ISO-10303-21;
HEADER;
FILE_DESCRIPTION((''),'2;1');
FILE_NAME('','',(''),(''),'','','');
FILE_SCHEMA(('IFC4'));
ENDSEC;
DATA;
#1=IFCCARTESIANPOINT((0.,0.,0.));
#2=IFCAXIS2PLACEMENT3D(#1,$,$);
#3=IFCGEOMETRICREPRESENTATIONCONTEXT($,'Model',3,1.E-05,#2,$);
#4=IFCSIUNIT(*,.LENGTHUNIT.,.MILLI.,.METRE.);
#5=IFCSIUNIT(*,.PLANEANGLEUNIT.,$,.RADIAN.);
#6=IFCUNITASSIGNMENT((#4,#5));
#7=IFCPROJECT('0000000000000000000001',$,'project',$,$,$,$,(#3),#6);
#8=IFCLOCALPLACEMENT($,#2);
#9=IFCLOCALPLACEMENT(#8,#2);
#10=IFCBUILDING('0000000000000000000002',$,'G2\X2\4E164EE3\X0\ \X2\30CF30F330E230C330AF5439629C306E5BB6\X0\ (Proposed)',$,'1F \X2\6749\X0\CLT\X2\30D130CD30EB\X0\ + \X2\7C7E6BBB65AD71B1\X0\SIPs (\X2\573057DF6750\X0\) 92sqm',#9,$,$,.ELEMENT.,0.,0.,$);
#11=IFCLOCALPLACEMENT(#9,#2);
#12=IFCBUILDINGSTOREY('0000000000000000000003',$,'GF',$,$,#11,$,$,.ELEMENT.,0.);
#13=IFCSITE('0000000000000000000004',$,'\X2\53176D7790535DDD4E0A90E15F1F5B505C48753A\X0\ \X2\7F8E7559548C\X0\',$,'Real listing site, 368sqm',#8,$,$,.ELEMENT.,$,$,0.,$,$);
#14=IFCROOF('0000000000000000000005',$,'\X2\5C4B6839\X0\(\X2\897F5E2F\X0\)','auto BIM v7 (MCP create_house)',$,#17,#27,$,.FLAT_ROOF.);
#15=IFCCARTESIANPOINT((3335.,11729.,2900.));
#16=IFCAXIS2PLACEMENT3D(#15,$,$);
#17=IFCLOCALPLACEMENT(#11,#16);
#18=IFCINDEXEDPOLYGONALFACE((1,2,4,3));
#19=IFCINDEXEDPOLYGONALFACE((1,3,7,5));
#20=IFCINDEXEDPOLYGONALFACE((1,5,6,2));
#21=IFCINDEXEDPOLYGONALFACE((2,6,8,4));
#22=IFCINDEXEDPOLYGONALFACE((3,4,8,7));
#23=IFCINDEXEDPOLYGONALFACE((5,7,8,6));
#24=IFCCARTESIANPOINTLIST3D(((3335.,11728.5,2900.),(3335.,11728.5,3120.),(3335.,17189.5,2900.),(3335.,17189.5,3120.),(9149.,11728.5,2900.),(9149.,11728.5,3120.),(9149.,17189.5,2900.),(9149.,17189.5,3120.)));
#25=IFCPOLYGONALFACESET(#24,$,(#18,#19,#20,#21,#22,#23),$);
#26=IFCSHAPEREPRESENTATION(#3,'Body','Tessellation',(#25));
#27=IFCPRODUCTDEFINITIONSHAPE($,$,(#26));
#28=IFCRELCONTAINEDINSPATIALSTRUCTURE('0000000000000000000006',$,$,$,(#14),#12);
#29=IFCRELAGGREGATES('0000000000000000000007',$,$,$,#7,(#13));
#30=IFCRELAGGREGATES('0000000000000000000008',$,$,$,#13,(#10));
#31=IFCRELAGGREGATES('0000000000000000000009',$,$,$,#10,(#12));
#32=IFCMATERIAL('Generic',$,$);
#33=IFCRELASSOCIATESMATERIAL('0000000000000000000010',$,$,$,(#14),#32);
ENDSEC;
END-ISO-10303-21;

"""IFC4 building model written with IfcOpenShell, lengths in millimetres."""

from ifc_helpers import new_model, si_unit, frame, frame_2d, origin, place, context, project, spatial, rectangle, extrude, material, element, save


model = new_model("IFC4")

# Units and contexts
model_context = context("Model", 3, precision=1e-05, world=origin())
ifc_project = project(units=[si_unit("LENGTHUNIT", "METRE", prefix="MILLI"), si_unit("PLANEANGLEUNIT", "RADIAN")], contexts=[model_context])

# Site, building, storey
site_placement = place(None, origin())
site = spatial("IfcSite", under=ifc_project, at=site_placement, Name="北海道川上郡弟子屈町 美留和", ObjectType="Real listing site, 368sqm", CompositionType="ELEMENT", RefElevation=0.0)
building_placement = place(site_placement, origin())
building = spatial("IfcBuilding", under=site, at=building_placement, Name="G2世代 ハンモック吹抜の家 (Proposed)", ObjectType="1F 杉CLTパネル + 籾殻断熱SIPs (地域材) 92sqm", CompositionType="ELEMENT", ElevationOfRefHeight=0.0, ElevationOfTerrain=0.0)
storey_placement = place(building_placement, origin())
storey = spatial("IfcBuildingStorey", under=building, at=storey_placement, Name="GF", CompositionType="ELEMENT", Elevation=0.0)

# Shared definitions
ifc_material = material(Name="Generic")

# Roof
roof_1_placement = place(storey_placement, frame((3335.0, 11729.0, 2900.0)))
element("IfcRoof", 1, at=roof_1_placement, inside=storey, material=ifc_material, Name="屋根(西帯)", Description="auto BIM v7 (MCP create_house)", PredefinedType="FLAT_ROOF", context=model_context, shape_type="SweptSolid", body=[
    extrude(rectangle(XDim=5814.0, YDim=5461.0, at=frame_2d((2907.0, 2730.0))), frame((3335.0, 11729.0, 2900.0)), (0.0, 0.0, 1.0), 220.0),
])

save(model, "model.ifc")
